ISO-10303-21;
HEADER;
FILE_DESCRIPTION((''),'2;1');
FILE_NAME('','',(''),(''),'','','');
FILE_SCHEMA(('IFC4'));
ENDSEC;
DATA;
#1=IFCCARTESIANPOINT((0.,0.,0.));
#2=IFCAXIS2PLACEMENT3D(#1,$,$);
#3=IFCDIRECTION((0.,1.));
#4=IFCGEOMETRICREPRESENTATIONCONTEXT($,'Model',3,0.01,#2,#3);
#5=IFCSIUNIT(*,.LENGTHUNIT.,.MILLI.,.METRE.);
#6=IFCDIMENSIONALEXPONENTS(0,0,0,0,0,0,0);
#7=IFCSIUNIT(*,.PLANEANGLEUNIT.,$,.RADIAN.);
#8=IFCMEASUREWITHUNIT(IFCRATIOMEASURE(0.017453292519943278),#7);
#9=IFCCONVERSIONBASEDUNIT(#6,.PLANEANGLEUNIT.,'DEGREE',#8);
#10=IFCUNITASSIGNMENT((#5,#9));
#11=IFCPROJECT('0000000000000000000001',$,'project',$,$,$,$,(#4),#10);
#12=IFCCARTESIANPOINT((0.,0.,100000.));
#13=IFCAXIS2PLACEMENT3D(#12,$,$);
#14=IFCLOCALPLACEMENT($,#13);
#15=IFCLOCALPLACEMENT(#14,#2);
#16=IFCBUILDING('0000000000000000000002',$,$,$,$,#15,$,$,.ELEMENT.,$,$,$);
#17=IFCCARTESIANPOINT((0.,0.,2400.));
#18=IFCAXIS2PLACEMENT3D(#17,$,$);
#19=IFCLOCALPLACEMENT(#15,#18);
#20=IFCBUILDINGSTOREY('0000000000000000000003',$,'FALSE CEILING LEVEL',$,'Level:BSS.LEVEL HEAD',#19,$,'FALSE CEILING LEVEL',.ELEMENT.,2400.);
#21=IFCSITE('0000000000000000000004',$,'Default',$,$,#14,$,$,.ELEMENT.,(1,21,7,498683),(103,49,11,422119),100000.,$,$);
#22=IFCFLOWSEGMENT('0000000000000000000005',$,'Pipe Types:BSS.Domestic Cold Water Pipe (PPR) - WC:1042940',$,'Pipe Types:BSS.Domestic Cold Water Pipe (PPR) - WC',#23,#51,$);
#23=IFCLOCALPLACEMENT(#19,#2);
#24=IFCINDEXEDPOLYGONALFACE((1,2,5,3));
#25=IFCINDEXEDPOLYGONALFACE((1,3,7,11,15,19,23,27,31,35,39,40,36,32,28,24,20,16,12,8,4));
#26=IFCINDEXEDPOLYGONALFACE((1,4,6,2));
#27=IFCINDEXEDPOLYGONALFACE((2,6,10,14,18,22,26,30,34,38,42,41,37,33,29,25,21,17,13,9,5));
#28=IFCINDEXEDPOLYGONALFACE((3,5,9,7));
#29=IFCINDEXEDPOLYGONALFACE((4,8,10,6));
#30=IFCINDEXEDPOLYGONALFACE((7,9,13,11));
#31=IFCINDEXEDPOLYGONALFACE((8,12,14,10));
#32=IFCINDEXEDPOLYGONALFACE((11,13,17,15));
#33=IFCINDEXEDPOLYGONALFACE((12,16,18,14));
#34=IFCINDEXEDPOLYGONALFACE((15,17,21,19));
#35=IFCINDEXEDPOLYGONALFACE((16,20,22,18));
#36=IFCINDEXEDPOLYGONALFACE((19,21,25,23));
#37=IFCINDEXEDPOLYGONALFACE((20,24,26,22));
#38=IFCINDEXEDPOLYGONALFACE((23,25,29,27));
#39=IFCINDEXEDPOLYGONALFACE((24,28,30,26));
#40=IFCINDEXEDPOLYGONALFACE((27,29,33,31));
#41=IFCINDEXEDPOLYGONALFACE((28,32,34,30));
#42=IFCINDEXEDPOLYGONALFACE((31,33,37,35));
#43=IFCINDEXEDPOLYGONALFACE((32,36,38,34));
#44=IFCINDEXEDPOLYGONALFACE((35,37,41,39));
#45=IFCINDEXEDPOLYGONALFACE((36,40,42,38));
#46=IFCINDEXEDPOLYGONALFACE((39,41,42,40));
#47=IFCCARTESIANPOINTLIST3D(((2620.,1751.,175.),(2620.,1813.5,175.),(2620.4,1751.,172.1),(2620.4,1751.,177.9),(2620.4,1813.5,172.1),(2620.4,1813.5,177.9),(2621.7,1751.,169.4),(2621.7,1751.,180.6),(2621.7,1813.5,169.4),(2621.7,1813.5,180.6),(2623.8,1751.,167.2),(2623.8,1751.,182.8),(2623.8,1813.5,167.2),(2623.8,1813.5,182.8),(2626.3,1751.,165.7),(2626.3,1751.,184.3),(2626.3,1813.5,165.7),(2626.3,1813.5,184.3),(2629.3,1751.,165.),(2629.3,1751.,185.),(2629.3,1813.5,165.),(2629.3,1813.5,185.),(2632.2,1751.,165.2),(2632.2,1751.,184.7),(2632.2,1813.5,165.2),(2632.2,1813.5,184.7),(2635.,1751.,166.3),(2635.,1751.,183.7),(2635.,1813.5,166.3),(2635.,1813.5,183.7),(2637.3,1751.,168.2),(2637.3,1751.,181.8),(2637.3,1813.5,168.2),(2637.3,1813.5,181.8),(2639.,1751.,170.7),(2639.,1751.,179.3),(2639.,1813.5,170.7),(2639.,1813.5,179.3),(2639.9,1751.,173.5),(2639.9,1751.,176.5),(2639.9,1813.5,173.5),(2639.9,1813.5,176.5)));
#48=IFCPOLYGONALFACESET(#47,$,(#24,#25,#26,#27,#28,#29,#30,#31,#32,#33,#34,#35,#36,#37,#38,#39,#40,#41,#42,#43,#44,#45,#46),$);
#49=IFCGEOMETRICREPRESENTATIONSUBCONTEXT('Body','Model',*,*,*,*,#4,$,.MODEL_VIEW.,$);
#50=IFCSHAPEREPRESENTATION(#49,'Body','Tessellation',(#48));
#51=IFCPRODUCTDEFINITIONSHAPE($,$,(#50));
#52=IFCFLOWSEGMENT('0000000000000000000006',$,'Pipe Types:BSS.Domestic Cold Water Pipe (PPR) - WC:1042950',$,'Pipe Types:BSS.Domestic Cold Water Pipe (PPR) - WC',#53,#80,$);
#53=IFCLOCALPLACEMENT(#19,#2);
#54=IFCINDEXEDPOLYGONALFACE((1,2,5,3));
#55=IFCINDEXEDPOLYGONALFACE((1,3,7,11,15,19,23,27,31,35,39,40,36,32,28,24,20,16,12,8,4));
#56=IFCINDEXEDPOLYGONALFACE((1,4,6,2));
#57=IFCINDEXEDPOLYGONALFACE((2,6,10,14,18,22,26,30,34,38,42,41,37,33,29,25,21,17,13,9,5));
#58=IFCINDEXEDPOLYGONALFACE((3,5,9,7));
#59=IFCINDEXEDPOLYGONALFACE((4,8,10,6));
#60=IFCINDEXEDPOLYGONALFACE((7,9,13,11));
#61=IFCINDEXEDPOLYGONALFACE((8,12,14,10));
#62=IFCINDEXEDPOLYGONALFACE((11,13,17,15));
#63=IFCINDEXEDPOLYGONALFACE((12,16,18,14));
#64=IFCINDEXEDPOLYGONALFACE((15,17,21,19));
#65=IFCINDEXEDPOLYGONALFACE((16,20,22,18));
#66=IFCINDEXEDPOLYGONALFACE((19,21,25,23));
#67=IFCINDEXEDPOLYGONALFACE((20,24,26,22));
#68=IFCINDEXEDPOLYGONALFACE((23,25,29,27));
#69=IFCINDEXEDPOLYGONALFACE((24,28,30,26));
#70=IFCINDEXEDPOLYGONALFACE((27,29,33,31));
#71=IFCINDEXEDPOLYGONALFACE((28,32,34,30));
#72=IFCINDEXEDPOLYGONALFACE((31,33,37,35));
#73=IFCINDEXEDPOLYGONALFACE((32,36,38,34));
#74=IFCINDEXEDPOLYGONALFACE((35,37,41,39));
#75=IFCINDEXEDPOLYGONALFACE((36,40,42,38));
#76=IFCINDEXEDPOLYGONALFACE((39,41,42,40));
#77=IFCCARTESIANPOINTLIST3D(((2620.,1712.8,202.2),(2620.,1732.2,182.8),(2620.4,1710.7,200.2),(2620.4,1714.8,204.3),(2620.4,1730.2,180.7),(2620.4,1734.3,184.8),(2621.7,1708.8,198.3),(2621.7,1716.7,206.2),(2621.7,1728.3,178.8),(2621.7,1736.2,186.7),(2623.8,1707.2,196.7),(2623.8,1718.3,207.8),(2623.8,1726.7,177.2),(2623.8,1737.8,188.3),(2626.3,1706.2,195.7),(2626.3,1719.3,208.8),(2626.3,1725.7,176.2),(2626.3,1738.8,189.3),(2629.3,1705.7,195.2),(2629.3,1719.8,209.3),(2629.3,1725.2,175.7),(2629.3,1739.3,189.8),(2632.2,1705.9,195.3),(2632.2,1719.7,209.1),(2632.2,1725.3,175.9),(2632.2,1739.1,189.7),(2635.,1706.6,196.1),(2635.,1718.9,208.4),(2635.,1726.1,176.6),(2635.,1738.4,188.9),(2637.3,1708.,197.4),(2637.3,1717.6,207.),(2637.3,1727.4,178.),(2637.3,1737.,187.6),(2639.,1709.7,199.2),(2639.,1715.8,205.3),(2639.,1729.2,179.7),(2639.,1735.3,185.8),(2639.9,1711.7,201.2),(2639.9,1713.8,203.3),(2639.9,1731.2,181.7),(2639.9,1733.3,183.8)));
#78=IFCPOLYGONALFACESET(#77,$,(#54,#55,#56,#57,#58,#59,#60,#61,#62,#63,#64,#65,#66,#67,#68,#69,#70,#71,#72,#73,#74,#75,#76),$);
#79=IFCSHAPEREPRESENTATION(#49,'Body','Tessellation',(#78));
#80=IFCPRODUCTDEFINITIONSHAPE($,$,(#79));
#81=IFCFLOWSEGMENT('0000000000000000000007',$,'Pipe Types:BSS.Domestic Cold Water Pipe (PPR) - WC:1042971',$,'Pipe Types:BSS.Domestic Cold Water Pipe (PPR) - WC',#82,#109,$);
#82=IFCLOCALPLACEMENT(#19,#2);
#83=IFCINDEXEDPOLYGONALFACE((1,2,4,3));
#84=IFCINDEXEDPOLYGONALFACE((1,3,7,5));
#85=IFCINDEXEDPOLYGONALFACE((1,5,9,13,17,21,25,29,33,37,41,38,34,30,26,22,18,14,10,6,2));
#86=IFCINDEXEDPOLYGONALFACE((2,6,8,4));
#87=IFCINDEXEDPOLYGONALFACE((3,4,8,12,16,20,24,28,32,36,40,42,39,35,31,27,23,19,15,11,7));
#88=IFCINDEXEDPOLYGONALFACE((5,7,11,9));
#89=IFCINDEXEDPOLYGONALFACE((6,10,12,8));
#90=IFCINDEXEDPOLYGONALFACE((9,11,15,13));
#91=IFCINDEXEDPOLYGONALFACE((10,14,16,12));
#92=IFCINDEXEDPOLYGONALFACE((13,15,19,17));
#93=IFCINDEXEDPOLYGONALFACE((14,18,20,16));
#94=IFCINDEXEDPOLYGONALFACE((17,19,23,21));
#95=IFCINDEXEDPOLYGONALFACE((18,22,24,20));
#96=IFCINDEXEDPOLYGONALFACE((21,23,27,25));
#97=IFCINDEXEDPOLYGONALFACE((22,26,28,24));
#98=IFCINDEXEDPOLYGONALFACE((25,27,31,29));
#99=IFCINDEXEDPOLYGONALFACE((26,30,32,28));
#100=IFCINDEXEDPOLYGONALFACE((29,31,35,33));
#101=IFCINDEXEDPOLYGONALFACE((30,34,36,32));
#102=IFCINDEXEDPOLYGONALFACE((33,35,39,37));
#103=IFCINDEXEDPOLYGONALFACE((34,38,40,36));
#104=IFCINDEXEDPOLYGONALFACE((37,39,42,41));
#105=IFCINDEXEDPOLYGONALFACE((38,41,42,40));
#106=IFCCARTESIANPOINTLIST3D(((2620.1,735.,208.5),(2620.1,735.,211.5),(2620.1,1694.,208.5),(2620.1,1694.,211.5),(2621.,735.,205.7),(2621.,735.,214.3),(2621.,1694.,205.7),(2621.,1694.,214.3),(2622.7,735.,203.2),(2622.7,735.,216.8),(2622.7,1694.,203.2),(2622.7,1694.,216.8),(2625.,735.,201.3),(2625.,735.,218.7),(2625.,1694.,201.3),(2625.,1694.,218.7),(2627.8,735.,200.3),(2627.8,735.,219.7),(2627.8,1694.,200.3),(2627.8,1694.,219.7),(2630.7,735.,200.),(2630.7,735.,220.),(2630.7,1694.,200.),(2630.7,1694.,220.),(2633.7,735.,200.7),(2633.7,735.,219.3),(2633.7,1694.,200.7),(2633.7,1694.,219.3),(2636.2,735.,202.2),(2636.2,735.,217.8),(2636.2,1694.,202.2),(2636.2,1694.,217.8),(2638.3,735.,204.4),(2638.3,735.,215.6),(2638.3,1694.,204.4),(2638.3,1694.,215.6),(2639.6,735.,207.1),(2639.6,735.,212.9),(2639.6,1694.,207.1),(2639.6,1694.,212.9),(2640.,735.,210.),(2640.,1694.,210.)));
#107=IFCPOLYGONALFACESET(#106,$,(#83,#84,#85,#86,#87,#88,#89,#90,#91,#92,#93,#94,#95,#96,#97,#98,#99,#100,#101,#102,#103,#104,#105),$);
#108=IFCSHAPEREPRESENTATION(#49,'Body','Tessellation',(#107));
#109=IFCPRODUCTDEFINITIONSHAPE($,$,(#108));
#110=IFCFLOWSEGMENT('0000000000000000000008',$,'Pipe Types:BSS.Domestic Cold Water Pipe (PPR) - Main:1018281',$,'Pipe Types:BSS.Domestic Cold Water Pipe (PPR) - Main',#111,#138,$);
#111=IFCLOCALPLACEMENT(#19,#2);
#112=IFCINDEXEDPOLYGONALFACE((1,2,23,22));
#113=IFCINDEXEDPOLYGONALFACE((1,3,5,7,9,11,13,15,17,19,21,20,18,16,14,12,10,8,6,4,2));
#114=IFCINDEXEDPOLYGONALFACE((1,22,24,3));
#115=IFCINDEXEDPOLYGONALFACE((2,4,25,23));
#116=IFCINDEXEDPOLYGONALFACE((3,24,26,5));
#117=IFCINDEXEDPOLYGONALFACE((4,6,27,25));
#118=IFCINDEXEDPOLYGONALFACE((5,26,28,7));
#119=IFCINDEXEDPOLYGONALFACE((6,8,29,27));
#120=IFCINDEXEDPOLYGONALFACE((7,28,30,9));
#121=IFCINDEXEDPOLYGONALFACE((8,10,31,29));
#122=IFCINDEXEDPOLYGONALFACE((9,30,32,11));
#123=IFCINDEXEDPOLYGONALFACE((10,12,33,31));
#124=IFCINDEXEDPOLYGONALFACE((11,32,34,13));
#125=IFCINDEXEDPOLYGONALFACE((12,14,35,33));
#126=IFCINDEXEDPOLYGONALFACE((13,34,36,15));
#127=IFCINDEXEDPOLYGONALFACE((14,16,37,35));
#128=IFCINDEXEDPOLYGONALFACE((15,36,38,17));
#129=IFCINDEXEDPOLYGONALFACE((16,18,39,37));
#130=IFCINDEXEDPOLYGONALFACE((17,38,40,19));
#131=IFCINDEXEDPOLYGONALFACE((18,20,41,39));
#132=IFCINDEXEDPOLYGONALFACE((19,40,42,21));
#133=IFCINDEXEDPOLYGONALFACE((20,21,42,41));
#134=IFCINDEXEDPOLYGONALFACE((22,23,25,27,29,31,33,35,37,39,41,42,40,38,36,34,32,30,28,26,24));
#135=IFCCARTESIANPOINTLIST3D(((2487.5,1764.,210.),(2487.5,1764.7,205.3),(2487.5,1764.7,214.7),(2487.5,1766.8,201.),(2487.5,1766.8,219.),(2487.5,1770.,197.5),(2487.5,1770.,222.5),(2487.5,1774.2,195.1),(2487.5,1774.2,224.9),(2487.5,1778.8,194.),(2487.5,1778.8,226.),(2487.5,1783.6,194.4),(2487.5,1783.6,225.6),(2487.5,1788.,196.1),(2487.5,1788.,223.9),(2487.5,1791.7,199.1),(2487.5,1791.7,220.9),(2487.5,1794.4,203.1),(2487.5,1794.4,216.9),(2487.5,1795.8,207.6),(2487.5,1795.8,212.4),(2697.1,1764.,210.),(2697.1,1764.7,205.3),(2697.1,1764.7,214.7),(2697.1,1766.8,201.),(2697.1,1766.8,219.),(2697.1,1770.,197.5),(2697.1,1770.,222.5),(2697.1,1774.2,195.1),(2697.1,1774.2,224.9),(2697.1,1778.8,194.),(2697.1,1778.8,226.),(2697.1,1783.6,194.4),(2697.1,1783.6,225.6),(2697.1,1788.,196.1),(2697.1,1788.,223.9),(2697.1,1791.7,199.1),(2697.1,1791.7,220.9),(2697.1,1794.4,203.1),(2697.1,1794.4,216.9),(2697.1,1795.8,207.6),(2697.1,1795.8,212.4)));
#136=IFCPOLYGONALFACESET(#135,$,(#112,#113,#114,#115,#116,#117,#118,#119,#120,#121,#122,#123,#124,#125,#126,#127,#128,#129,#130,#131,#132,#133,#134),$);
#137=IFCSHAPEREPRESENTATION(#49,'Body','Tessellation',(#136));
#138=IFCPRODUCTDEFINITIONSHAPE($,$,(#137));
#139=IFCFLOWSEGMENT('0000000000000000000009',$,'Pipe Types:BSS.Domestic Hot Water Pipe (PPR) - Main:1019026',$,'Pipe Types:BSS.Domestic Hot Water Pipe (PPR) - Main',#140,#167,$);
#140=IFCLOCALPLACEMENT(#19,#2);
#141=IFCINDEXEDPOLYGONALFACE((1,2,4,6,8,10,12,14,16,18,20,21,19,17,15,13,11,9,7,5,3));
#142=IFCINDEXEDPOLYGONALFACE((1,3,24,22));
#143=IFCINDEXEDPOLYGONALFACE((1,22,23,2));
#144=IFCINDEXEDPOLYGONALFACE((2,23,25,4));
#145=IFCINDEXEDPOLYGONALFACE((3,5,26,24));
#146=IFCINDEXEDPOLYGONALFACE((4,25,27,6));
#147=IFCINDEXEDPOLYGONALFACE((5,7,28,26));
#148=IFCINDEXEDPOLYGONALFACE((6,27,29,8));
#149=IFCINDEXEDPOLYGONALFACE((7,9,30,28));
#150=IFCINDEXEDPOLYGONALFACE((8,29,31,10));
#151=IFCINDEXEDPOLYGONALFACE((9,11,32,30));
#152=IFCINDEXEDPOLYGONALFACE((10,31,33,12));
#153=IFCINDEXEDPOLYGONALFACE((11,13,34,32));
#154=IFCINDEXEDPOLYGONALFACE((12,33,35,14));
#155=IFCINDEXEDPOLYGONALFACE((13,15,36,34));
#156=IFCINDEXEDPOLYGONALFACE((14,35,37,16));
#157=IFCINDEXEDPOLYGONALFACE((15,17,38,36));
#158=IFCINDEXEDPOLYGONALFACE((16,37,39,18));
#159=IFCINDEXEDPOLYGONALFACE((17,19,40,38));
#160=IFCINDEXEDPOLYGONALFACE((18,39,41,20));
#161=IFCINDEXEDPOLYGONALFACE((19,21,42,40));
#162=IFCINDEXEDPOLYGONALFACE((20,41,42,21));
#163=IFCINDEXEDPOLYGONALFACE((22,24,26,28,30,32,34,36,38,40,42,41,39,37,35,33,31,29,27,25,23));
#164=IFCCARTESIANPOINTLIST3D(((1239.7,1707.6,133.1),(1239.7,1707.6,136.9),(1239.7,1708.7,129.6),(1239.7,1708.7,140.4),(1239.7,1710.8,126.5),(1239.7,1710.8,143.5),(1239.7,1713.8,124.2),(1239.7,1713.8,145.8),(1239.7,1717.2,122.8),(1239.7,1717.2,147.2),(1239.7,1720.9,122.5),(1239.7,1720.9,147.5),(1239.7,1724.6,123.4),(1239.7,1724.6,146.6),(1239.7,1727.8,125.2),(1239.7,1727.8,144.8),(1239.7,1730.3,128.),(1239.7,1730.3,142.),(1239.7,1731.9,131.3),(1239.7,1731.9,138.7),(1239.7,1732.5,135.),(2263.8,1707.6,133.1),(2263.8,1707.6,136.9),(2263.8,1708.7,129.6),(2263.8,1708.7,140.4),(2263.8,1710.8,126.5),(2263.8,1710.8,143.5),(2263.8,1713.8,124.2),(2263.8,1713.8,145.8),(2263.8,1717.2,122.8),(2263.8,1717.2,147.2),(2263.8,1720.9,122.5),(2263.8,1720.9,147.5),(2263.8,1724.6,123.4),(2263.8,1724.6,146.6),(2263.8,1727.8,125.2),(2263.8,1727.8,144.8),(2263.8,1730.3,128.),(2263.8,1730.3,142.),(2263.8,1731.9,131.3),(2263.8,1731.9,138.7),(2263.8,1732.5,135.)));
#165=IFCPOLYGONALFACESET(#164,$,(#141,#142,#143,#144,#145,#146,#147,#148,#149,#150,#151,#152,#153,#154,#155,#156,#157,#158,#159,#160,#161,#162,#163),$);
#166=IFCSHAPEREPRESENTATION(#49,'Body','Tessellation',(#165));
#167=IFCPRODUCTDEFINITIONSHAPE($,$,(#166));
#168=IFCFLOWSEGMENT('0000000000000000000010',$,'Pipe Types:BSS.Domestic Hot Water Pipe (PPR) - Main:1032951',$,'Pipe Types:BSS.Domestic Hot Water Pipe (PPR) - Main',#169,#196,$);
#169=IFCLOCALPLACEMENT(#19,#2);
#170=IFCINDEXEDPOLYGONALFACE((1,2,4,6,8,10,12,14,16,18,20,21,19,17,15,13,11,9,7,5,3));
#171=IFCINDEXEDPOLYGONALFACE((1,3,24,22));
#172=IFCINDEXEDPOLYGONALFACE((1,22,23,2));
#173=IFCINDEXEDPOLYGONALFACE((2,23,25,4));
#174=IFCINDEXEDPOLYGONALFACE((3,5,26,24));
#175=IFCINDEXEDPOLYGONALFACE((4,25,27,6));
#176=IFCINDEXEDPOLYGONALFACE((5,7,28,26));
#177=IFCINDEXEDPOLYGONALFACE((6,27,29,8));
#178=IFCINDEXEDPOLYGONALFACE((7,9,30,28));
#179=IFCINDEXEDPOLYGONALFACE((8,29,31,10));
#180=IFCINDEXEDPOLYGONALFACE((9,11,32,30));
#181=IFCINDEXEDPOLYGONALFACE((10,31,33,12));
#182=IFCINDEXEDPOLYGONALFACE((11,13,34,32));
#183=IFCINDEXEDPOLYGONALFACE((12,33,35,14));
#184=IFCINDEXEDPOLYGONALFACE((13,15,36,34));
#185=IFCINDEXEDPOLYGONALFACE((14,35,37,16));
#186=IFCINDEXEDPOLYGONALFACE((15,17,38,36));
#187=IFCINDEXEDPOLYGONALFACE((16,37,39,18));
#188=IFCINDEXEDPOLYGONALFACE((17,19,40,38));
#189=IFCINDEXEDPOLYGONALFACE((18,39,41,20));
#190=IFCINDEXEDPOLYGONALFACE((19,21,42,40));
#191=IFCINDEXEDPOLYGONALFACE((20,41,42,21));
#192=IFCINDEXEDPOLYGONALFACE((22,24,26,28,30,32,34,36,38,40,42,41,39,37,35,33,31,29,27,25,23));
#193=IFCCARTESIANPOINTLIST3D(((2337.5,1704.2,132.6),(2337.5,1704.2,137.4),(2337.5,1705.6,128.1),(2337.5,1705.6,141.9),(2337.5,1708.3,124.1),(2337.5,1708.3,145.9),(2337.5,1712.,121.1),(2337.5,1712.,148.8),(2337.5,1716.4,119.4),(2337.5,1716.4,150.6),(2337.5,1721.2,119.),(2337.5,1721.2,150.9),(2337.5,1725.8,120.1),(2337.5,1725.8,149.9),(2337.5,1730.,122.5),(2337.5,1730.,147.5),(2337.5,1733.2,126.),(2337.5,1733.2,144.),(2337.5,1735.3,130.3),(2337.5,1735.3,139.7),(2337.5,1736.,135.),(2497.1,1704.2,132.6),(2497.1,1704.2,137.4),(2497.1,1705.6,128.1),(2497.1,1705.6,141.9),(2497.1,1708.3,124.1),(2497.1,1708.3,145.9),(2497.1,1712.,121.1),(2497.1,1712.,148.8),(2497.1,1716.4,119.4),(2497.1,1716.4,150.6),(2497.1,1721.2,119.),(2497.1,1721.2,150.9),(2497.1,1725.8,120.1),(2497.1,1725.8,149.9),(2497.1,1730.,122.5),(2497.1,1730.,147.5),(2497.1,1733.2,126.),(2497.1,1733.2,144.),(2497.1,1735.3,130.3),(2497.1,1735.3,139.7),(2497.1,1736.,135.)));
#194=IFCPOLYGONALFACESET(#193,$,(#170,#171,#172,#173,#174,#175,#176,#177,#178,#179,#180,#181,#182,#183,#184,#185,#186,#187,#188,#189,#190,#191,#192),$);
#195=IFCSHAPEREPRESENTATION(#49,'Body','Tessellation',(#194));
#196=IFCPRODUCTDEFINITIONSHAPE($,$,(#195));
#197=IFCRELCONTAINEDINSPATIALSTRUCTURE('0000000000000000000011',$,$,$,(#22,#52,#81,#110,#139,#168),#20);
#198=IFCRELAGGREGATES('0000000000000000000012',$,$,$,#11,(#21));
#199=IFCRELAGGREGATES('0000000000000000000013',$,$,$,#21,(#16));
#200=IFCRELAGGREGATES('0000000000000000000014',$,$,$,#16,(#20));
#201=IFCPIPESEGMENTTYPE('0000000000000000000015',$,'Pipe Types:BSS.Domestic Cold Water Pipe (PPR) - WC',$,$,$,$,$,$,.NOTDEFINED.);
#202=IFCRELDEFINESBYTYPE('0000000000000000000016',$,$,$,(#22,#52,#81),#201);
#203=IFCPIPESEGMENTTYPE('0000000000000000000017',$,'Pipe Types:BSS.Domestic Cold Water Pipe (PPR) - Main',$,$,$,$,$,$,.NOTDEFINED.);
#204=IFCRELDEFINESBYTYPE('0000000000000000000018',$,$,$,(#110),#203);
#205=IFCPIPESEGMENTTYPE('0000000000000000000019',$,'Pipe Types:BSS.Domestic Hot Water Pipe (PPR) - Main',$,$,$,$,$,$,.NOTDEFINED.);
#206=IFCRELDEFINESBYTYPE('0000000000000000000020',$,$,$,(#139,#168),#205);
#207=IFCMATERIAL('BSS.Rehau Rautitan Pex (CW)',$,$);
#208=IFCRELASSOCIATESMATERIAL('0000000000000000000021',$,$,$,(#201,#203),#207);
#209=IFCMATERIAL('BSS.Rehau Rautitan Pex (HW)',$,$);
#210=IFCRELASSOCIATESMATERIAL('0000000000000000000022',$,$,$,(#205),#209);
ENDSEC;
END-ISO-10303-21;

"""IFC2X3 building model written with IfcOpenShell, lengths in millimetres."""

from ifc_helpers import new_model, entity, si_unit, converted_unit, direction, frame, frame_2d, origin, origin_2d_with_axis, place, context, subcontext, project, spatial, circle, extrude, material, type_object, element, save


model = new_model("IFC2X3")

# Units and contexts
model_context = context("Model", 3, precision=0.01, world=origin(), true_north=direction((0.0, 1.0)))
body_context = subcontext(model_context, "Body", "Model", "MODEL_VIEW")
ifc_project = project(units=[si_unit("LENGTHUNIT", "METRE", prefix="MILLI"), converted_unit("PLANEANGLEUNIT", "DEGREE", entity("IfcRatioMeasure", 0.017453292519943278), si_unit("PLANEANGLEUNIT", "RADIAN"), dimensions=[0, 0, 0, 0, 0, 0, 0])], contexts=[model_context])

# Site, building, storey
site_placement = place(None, frame((0.0, 0.0, 100000.0)))
site = spatial("IfcSite", under=ifc_project, at=site_placement, Name="Default", CompositionType="ELEMENT", RefLatitude=(1, 21, 7, 498683), RefLongitude=(103, 49, 11, 422119), RefElevation=100000.0)
building_placement = place(site_placement, origin())
building = spatial("IfcBuilding", under=site, at=building_placement, CompositionType="ELEMENT")
storey_placement = place(building_placement, frame((0.0, 0.0, 2400.0)))
storey = spatial("IfcBuildingStorey", under=building, at=storey_placement, Name="FALSE CEILING LEVEL", ObjectType="Level:BSS.LEVEL HEAD", LongName="FALSE CEILING LEVEL", CompositionType="ELEMENT", Elevation=2400.0)

# Flow segments
ifc_material_1 = material(Name="BSS.Rehau Rautitan Pex (HW)")
ifc_material_2 = material(Name="BSS.Rehau Rautitan Pex (CW)")
pipe_segment_type_1 = type_object("IfcPipeSegmentType", Name="Pipe Types:BSS.Domestic Cold Water Pipe (PPR) - WC", PredefinedType="NOTDEFINED", material=ifc_material_2)
flow_segment_1_placement = place(storey_placement, origin())
element("IfcFlowSegment", 1, at=flow_segment_1_placement, inside=storey, type_object=pipe_segment_type_1, Name="Pipe Types:BSS.Domestic Cold Water Pipe (PPR) - WC:1042940", ObjectType="Pipe Types:BSS.Domestic Cold Water Pipe (PPR) - WC", context=body_context, shape_type="SweptSolid", body=[
    extrude(circle(Radius=10.0, at=frame_2d((0.0, 0.0), x_axis=(1.0, 0.0))), frame((2630.0, 1751.0, 175.0), z_axis=(0.0, 1.0, 0.0), x_axis=(-1.0, 0.0, 0.0)), (0.0, 0.0, 1.0), 62.5),
])
flow_segment_2_placement = place(storey_placement, origin())
element("IfcFlowSegment", 2, at=flow_segment_2_placement, inside=storey, type_object=pipe_segment_type_1, Name="Pipe Types:BSS.Domestic Cold Water Pipe (PPR) - WC:1042950", ObjectType="Pipe Types:BSS.Domestic Cold Water Pipe (PPR) - WC", context=body_context, shape_type="SweptSolid", body=[
    extrude(circle(Radius=10.0, at=frame_2d((0.0, 0.0), x_axis=(1.0, 0.0))), frame((2630.0, 1712.8, 202.2), z_axis=(0.0, 0.707107, -0.707107), x_axis=(-1.0, 0.0, 0.0)), (0.0, 0.0, 1.0), 27.5),
])
flow_segment_3_placement = place(storey_placement, origin())
element("IfcFlowSegment", 3, at=flow_segment_3_placement, inside=storey, type_object=pipe_segment_type_1, Name="Pipe Types:BSS.Domestic Cold Water Pipe (PPR) - WC:1042971", ObjectType="Pipe Types:BSS.Domestic Cold Water Pipe (PPR) - WC", context=body_context, shape_type="SweptSolid", body=[
    extrude(circle(Radius=10.0, at=origin_2d_with_axis()), frame((2630.0, 735.0, 210.0), z_axis=(0.0, 1.0, 0.0), x_axis=(1.0, 0.0, 0.0)), (0.0, 0.0, 1.0), 959.0),
])
pipe_segment_type_2 = type_object("IfcPipeSegmentType", Name="Pipe Types:BSS.Domestic Cold Water Pipe (PPR) - Main", PredefinedType="NOTDEFINED", material=ifc_material_2)
flow_segment_4_placement = place(storey_placement, origin())
element("IfcFlowSegment", 4, at=flow_segment_4_placement, inside=storey, type_object=pipe_segment_type_2, Name="Pipe Types:BSS.Domestic Cold Water Pipe (PPR) - Main:1018281", ObjectType="Pipe Types:BSS.Domestic Cold Water Pipe (PPR) - Main", context=body_context, shape_type="SweptSolid", body=[
    extrude(circle(Radius=16.0, at=frame_2d((0.0, 0.0), x_axis=(1.0, 0.0))), frame((2487.5, 1780.0, 210.0), z_axis=(1.0, 0.0, 0.0), x_axis=(0.0, -1.0, 0.0)), (0.0, 0.0, 1.0), 209.7),
])
pipe_segment_type_3 = type_object("IfcPipeSegmentType", Name="Pipe Types:BSS.Domestic Hot Water Pipe (PPR) - Main", PredefinedType="NOTDEFINED", material=ifc_material_1)
flow_segment_5_placement = place(storey_placement, origin())
element("IfcFlowSegment", 5, at=flow_segment_5_placement, inside=storey, type_object=pipe_segment_type_3, Name="Pipe Types:BSS.Domestic Hot Water Pipe (PPR) - Main:1019026", ObjectType="Pipe Types:BSS.Domestic Hot Water Pipe (PPR) - Main", context=body_context, shape_type="SweptSolid", body=[
    extrude(circle(Radius=12.5, at=frame_2d((0.0, 0.0), x_axis=(1.0, 0.0))), frame((1239.7, 1720.0, 135.0), z_axis=(1.0, 0.0, 0.0), x_axis=(0.0, 1.0, 0.0)), (0.0, 0.0, 1.0), 1024.1),
])
flow_segment_6_placement = place(storey_placement, origin())
element("IfcFlowSegment", 6, at=flow_segment_6_placement, inside=storey, type_object=pipe_segment_type_3, Name="Pipe Types:BSS.Domestic Hot Water Pipe (PPR) - Main:1032951", ObjectType="Pipe Types:BSS.Domestic Hot Water Pipe (PPR) - Main", context=body_context, shape_type="SweptSolid", body=[
    extrude(circle(Radius=16.0, at=origin_2d_with_axis()), frame((2337.5, 1720.0, 135.0), z_axis=(1.0, 0.0, 0.0), x_axis=(0.0, 1.0, 0.0)), (0.0, 0.0, 1.0), 159.7),
])

save(model, "model.ifc")
